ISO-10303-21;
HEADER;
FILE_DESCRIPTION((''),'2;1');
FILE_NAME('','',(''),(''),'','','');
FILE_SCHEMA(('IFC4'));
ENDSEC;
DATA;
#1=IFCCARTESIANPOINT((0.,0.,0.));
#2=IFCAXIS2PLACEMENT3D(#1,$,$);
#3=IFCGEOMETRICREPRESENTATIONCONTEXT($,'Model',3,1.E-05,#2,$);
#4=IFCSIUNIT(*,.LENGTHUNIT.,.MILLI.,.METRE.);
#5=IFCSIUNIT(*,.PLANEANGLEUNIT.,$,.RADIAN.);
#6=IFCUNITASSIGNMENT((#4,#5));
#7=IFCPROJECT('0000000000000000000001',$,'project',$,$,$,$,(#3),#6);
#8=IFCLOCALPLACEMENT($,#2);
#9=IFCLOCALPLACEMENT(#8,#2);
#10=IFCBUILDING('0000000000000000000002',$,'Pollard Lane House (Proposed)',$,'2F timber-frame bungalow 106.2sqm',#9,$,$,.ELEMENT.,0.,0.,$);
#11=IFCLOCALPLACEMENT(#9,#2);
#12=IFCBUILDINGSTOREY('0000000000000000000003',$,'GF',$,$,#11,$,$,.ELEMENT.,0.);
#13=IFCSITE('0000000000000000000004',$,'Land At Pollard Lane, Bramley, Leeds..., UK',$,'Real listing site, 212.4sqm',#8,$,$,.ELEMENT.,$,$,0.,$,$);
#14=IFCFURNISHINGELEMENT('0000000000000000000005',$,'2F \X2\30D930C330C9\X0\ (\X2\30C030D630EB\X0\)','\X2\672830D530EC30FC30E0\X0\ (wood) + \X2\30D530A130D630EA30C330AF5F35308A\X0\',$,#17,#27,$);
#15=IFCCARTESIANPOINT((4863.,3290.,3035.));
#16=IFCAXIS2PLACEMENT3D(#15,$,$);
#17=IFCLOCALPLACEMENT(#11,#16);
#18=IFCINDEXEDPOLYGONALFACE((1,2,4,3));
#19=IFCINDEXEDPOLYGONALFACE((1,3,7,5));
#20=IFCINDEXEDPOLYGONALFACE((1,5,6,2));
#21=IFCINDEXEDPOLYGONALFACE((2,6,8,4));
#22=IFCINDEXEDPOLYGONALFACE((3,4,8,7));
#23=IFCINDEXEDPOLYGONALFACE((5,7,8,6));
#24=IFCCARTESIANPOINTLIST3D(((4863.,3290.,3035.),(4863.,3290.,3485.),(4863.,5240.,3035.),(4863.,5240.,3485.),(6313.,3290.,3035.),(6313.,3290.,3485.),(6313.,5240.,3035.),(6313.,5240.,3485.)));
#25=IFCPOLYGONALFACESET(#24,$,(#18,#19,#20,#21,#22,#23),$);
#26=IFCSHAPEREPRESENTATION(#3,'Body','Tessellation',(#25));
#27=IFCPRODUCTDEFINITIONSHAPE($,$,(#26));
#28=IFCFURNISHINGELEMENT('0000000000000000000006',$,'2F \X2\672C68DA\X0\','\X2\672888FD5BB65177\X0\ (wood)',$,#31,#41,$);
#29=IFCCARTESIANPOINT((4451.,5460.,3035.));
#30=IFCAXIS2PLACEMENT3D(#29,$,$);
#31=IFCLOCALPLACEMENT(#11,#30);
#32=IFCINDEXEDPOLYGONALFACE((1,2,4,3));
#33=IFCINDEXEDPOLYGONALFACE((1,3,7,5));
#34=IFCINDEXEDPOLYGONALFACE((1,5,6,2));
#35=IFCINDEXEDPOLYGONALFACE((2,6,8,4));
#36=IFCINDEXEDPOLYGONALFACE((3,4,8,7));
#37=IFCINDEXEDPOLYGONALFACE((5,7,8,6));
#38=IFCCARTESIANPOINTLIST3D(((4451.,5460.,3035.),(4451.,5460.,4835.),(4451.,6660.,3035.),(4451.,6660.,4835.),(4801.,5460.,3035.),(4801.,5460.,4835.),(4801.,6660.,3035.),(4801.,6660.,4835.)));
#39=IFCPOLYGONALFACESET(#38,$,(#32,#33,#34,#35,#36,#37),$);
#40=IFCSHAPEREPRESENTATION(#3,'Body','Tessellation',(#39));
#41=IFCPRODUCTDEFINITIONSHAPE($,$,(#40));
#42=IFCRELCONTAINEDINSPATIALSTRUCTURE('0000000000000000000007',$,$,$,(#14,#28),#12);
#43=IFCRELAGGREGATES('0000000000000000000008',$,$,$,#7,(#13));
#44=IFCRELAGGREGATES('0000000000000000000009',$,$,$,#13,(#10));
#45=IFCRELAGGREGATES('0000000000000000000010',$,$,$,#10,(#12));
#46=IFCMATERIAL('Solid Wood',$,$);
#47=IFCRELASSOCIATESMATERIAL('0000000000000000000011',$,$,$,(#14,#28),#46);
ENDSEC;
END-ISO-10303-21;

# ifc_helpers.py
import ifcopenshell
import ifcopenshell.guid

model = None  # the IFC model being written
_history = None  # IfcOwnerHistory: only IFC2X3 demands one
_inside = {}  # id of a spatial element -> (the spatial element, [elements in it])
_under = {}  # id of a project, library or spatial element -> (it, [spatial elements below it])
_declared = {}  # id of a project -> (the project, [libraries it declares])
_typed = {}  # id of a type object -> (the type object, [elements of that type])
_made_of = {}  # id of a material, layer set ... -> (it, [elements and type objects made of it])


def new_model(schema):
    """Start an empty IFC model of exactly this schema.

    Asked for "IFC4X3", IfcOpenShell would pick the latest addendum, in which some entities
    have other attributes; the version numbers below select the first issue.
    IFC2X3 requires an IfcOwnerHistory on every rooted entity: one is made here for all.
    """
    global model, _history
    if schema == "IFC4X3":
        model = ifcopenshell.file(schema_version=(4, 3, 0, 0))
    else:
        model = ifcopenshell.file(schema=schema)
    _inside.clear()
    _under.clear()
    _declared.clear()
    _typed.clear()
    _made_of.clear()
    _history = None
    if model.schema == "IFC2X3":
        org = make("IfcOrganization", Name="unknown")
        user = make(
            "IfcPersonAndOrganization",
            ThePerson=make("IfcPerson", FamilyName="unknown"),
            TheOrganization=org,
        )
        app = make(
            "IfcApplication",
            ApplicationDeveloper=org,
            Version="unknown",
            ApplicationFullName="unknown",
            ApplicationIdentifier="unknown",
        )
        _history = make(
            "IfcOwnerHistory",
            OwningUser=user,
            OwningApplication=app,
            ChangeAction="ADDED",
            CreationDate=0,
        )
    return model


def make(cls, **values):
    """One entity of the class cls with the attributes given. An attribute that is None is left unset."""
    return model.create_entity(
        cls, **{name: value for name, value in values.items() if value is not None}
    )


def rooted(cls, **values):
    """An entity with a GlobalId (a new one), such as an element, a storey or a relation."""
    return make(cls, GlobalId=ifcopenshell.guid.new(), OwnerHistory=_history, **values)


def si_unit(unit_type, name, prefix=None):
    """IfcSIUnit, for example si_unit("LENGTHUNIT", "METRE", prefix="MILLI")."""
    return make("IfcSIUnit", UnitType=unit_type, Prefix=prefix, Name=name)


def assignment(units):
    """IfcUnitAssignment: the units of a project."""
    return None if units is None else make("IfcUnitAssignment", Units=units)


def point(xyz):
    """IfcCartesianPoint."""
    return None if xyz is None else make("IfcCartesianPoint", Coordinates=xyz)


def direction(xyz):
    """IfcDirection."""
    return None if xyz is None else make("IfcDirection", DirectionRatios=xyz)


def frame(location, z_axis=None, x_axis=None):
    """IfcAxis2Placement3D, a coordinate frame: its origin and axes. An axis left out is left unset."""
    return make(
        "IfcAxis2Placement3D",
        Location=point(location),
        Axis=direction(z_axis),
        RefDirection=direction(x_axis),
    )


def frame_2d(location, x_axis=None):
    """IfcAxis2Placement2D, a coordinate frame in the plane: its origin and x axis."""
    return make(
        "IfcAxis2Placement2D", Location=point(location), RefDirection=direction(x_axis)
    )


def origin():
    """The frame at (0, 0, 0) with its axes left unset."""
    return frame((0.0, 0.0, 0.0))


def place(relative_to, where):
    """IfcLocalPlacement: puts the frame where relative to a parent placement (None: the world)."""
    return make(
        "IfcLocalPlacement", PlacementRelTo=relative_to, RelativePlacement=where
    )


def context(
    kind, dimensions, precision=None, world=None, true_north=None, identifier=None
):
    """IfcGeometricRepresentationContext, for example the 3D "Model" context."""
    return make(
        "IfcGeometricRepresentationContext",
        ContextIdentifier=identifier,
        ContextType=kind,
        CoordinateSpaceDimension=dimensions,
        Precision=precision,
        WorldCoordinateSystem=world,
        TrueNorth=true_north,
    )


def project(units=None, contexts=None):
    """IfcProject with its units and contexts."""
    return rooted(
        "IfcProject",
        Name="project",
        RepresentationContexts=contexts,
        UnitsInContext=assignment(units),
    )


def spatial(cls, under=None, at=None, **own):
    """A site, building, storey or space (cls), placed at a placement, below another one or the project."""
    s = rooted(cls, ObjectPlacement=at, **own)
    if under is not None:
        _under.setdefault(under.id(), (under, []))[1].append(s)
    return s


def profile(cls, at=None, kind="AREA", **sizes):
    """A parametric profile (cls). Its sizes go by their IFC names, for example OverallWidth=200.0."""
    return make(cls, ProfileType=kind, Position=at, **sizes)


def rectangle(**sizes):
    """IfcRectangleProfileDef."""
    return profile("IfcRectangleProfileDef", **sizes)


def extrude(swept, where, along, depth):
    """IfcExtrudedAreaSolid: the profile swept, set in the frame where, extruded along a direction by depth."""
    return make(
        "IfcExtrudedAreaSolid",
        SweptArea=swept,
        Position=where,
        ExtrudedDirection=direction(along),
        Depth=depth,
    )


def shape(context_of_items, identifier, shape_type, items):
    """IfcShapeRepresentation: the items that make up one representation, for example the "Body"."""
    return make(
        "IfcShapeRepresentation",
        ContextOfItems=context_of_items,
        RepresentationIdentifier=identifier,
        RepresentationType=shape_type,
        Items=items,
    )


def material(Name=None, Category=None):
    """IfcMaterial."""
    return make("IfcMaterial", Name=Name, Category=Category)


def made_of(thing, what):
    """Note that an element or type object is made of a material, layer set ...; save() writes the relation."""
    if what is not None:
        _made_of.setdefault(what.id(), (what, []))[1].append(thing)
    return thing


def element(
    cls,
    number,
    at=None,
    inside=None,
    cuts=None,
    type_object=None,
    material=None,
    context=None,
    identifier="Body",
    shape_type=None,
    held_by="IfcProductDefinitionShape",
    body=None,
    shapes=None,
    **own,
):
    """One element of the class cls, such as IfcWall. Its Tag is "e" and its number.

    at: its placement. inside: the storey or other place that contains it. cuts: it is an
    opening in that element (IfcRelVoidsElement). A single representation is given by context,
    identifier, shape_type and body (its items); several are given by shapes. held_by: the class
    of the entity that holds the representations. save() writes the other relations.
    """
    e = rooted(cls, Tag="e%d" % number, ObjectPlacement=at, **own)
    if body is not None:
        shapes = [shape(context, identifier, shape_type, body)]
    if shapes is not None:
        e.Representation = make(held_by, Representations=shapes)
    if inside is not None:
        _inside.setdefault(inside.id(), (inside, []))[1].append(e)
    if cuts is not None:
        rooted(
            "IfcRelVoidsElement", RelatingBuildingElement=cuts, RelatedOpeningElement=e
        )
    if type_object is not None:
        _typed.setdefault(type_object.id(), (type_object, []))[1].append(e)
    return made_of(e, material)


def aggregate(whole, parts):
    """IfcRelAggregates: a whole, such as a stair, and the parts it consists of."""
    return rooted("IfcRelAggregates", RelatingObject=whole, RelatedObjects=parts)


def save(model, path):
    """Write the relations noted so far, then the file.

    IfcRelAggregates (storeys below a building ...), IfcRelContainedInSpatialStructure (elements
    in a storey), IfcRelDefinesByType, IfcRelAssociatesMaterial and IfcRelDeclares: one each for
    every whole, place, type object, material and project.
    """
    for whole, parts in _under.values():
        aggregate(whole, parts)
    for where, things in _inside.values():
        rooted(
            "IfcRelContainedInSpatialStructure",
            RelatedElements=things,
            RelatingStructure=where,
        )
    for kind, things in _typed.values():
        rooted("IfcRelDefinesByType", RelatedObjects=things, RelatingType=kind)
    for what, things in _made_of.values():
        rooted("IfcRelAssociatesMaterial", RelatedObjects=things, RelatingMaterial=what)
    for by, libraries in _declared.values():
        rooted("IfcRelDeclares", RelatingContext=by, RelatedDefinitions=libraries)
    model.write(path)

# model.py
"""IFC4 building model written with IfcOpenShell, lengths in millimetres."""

from ifc_helpers import new_model, si_unit, frame, frame_2d, origin, place, context, project, spatial, rectangle, extrude, material, element, save


model = new_model("IFC4")

# Units and contexts
model_context = context("Model", 3, precision=1e-05, world=origin())
ifc_project = project(units=[si_unit("LENGTHUNIT", "METRE", prefix="MILLI"), si_unit("PLANEANGLEUNIT", "RADIAN")], contexts=[model_context])

# Site, building, storey
site_placement = place(None, origin())
site = spatial("IfcSite", under=ifc_project, at=site_placement, Name="Land At Pollard Lane, Bramley, Leeds..., UK", ObjectType="Real listing site, 212.4sqm", CompositionType="ELEMENT", RefElevation=0.0)
building_placement = place(site_placement, origin())
building = spatial("IfcBuilding", under=site, at=building_placement, Name="Pollard Lane House (Proposed)", ObjectType="2F timber-frame bungalow 106.2sqm", CompositionType="ELEMENT", ElevationOfRefHeight=0.0, ElevationOfTerrain=0.0)
storey_placement = place(building_placement, origin())
storey = spatial("IfcBuildingStorey", under=building, at=storey_placement, Name="GF", CompositionType="ELEMENT", Elevation=0.0)

# Shared definitions
ifc_material_1 = material(Name="Solid Wood")

# Furnishing elements
furnishing_1_placement = place(storey_placement, frame((4863.0, 3290.0, 3035.0)))
element("IfcFurnishingElement", 1, at=furnishing_1_placement, inside=storey, material=ifc_material_1, Name="2F ベッド (ダブル)", Description="木フレーム (wood) + ファブリック張り", context=model_context, shape_type="SweptSolid", body=[
    extrude(rectangle(XDim=1450.0, YDim=1950.0, at=frame_2d((725.0, 975.0))), frame((4863.0, 3290.0, 3035.0)), (0.0, 0.0, 1.0), 450.0),
])
furnishing_2_placement = place(storey_placement, frame((4451.0, 5460.0, 3035.0)))
element("IfcFurnishingElement", 2, at=furnishing_2_placement, inside=storey, material=ifc_material_1, Name="2F 本棚", Description="木製家具 (wood)", context=model_context, shape_type="SweptSolid", body=[
    extrude(rectangle(XDim=350.0, YDim=1200.0, at=frame_2d((175.0, 600.0))), frame((4451.0, 5460.0, 3035.0)), (0.0, 0.0, 1.0), 1800.0),
])

save(model, "model.ifc")
